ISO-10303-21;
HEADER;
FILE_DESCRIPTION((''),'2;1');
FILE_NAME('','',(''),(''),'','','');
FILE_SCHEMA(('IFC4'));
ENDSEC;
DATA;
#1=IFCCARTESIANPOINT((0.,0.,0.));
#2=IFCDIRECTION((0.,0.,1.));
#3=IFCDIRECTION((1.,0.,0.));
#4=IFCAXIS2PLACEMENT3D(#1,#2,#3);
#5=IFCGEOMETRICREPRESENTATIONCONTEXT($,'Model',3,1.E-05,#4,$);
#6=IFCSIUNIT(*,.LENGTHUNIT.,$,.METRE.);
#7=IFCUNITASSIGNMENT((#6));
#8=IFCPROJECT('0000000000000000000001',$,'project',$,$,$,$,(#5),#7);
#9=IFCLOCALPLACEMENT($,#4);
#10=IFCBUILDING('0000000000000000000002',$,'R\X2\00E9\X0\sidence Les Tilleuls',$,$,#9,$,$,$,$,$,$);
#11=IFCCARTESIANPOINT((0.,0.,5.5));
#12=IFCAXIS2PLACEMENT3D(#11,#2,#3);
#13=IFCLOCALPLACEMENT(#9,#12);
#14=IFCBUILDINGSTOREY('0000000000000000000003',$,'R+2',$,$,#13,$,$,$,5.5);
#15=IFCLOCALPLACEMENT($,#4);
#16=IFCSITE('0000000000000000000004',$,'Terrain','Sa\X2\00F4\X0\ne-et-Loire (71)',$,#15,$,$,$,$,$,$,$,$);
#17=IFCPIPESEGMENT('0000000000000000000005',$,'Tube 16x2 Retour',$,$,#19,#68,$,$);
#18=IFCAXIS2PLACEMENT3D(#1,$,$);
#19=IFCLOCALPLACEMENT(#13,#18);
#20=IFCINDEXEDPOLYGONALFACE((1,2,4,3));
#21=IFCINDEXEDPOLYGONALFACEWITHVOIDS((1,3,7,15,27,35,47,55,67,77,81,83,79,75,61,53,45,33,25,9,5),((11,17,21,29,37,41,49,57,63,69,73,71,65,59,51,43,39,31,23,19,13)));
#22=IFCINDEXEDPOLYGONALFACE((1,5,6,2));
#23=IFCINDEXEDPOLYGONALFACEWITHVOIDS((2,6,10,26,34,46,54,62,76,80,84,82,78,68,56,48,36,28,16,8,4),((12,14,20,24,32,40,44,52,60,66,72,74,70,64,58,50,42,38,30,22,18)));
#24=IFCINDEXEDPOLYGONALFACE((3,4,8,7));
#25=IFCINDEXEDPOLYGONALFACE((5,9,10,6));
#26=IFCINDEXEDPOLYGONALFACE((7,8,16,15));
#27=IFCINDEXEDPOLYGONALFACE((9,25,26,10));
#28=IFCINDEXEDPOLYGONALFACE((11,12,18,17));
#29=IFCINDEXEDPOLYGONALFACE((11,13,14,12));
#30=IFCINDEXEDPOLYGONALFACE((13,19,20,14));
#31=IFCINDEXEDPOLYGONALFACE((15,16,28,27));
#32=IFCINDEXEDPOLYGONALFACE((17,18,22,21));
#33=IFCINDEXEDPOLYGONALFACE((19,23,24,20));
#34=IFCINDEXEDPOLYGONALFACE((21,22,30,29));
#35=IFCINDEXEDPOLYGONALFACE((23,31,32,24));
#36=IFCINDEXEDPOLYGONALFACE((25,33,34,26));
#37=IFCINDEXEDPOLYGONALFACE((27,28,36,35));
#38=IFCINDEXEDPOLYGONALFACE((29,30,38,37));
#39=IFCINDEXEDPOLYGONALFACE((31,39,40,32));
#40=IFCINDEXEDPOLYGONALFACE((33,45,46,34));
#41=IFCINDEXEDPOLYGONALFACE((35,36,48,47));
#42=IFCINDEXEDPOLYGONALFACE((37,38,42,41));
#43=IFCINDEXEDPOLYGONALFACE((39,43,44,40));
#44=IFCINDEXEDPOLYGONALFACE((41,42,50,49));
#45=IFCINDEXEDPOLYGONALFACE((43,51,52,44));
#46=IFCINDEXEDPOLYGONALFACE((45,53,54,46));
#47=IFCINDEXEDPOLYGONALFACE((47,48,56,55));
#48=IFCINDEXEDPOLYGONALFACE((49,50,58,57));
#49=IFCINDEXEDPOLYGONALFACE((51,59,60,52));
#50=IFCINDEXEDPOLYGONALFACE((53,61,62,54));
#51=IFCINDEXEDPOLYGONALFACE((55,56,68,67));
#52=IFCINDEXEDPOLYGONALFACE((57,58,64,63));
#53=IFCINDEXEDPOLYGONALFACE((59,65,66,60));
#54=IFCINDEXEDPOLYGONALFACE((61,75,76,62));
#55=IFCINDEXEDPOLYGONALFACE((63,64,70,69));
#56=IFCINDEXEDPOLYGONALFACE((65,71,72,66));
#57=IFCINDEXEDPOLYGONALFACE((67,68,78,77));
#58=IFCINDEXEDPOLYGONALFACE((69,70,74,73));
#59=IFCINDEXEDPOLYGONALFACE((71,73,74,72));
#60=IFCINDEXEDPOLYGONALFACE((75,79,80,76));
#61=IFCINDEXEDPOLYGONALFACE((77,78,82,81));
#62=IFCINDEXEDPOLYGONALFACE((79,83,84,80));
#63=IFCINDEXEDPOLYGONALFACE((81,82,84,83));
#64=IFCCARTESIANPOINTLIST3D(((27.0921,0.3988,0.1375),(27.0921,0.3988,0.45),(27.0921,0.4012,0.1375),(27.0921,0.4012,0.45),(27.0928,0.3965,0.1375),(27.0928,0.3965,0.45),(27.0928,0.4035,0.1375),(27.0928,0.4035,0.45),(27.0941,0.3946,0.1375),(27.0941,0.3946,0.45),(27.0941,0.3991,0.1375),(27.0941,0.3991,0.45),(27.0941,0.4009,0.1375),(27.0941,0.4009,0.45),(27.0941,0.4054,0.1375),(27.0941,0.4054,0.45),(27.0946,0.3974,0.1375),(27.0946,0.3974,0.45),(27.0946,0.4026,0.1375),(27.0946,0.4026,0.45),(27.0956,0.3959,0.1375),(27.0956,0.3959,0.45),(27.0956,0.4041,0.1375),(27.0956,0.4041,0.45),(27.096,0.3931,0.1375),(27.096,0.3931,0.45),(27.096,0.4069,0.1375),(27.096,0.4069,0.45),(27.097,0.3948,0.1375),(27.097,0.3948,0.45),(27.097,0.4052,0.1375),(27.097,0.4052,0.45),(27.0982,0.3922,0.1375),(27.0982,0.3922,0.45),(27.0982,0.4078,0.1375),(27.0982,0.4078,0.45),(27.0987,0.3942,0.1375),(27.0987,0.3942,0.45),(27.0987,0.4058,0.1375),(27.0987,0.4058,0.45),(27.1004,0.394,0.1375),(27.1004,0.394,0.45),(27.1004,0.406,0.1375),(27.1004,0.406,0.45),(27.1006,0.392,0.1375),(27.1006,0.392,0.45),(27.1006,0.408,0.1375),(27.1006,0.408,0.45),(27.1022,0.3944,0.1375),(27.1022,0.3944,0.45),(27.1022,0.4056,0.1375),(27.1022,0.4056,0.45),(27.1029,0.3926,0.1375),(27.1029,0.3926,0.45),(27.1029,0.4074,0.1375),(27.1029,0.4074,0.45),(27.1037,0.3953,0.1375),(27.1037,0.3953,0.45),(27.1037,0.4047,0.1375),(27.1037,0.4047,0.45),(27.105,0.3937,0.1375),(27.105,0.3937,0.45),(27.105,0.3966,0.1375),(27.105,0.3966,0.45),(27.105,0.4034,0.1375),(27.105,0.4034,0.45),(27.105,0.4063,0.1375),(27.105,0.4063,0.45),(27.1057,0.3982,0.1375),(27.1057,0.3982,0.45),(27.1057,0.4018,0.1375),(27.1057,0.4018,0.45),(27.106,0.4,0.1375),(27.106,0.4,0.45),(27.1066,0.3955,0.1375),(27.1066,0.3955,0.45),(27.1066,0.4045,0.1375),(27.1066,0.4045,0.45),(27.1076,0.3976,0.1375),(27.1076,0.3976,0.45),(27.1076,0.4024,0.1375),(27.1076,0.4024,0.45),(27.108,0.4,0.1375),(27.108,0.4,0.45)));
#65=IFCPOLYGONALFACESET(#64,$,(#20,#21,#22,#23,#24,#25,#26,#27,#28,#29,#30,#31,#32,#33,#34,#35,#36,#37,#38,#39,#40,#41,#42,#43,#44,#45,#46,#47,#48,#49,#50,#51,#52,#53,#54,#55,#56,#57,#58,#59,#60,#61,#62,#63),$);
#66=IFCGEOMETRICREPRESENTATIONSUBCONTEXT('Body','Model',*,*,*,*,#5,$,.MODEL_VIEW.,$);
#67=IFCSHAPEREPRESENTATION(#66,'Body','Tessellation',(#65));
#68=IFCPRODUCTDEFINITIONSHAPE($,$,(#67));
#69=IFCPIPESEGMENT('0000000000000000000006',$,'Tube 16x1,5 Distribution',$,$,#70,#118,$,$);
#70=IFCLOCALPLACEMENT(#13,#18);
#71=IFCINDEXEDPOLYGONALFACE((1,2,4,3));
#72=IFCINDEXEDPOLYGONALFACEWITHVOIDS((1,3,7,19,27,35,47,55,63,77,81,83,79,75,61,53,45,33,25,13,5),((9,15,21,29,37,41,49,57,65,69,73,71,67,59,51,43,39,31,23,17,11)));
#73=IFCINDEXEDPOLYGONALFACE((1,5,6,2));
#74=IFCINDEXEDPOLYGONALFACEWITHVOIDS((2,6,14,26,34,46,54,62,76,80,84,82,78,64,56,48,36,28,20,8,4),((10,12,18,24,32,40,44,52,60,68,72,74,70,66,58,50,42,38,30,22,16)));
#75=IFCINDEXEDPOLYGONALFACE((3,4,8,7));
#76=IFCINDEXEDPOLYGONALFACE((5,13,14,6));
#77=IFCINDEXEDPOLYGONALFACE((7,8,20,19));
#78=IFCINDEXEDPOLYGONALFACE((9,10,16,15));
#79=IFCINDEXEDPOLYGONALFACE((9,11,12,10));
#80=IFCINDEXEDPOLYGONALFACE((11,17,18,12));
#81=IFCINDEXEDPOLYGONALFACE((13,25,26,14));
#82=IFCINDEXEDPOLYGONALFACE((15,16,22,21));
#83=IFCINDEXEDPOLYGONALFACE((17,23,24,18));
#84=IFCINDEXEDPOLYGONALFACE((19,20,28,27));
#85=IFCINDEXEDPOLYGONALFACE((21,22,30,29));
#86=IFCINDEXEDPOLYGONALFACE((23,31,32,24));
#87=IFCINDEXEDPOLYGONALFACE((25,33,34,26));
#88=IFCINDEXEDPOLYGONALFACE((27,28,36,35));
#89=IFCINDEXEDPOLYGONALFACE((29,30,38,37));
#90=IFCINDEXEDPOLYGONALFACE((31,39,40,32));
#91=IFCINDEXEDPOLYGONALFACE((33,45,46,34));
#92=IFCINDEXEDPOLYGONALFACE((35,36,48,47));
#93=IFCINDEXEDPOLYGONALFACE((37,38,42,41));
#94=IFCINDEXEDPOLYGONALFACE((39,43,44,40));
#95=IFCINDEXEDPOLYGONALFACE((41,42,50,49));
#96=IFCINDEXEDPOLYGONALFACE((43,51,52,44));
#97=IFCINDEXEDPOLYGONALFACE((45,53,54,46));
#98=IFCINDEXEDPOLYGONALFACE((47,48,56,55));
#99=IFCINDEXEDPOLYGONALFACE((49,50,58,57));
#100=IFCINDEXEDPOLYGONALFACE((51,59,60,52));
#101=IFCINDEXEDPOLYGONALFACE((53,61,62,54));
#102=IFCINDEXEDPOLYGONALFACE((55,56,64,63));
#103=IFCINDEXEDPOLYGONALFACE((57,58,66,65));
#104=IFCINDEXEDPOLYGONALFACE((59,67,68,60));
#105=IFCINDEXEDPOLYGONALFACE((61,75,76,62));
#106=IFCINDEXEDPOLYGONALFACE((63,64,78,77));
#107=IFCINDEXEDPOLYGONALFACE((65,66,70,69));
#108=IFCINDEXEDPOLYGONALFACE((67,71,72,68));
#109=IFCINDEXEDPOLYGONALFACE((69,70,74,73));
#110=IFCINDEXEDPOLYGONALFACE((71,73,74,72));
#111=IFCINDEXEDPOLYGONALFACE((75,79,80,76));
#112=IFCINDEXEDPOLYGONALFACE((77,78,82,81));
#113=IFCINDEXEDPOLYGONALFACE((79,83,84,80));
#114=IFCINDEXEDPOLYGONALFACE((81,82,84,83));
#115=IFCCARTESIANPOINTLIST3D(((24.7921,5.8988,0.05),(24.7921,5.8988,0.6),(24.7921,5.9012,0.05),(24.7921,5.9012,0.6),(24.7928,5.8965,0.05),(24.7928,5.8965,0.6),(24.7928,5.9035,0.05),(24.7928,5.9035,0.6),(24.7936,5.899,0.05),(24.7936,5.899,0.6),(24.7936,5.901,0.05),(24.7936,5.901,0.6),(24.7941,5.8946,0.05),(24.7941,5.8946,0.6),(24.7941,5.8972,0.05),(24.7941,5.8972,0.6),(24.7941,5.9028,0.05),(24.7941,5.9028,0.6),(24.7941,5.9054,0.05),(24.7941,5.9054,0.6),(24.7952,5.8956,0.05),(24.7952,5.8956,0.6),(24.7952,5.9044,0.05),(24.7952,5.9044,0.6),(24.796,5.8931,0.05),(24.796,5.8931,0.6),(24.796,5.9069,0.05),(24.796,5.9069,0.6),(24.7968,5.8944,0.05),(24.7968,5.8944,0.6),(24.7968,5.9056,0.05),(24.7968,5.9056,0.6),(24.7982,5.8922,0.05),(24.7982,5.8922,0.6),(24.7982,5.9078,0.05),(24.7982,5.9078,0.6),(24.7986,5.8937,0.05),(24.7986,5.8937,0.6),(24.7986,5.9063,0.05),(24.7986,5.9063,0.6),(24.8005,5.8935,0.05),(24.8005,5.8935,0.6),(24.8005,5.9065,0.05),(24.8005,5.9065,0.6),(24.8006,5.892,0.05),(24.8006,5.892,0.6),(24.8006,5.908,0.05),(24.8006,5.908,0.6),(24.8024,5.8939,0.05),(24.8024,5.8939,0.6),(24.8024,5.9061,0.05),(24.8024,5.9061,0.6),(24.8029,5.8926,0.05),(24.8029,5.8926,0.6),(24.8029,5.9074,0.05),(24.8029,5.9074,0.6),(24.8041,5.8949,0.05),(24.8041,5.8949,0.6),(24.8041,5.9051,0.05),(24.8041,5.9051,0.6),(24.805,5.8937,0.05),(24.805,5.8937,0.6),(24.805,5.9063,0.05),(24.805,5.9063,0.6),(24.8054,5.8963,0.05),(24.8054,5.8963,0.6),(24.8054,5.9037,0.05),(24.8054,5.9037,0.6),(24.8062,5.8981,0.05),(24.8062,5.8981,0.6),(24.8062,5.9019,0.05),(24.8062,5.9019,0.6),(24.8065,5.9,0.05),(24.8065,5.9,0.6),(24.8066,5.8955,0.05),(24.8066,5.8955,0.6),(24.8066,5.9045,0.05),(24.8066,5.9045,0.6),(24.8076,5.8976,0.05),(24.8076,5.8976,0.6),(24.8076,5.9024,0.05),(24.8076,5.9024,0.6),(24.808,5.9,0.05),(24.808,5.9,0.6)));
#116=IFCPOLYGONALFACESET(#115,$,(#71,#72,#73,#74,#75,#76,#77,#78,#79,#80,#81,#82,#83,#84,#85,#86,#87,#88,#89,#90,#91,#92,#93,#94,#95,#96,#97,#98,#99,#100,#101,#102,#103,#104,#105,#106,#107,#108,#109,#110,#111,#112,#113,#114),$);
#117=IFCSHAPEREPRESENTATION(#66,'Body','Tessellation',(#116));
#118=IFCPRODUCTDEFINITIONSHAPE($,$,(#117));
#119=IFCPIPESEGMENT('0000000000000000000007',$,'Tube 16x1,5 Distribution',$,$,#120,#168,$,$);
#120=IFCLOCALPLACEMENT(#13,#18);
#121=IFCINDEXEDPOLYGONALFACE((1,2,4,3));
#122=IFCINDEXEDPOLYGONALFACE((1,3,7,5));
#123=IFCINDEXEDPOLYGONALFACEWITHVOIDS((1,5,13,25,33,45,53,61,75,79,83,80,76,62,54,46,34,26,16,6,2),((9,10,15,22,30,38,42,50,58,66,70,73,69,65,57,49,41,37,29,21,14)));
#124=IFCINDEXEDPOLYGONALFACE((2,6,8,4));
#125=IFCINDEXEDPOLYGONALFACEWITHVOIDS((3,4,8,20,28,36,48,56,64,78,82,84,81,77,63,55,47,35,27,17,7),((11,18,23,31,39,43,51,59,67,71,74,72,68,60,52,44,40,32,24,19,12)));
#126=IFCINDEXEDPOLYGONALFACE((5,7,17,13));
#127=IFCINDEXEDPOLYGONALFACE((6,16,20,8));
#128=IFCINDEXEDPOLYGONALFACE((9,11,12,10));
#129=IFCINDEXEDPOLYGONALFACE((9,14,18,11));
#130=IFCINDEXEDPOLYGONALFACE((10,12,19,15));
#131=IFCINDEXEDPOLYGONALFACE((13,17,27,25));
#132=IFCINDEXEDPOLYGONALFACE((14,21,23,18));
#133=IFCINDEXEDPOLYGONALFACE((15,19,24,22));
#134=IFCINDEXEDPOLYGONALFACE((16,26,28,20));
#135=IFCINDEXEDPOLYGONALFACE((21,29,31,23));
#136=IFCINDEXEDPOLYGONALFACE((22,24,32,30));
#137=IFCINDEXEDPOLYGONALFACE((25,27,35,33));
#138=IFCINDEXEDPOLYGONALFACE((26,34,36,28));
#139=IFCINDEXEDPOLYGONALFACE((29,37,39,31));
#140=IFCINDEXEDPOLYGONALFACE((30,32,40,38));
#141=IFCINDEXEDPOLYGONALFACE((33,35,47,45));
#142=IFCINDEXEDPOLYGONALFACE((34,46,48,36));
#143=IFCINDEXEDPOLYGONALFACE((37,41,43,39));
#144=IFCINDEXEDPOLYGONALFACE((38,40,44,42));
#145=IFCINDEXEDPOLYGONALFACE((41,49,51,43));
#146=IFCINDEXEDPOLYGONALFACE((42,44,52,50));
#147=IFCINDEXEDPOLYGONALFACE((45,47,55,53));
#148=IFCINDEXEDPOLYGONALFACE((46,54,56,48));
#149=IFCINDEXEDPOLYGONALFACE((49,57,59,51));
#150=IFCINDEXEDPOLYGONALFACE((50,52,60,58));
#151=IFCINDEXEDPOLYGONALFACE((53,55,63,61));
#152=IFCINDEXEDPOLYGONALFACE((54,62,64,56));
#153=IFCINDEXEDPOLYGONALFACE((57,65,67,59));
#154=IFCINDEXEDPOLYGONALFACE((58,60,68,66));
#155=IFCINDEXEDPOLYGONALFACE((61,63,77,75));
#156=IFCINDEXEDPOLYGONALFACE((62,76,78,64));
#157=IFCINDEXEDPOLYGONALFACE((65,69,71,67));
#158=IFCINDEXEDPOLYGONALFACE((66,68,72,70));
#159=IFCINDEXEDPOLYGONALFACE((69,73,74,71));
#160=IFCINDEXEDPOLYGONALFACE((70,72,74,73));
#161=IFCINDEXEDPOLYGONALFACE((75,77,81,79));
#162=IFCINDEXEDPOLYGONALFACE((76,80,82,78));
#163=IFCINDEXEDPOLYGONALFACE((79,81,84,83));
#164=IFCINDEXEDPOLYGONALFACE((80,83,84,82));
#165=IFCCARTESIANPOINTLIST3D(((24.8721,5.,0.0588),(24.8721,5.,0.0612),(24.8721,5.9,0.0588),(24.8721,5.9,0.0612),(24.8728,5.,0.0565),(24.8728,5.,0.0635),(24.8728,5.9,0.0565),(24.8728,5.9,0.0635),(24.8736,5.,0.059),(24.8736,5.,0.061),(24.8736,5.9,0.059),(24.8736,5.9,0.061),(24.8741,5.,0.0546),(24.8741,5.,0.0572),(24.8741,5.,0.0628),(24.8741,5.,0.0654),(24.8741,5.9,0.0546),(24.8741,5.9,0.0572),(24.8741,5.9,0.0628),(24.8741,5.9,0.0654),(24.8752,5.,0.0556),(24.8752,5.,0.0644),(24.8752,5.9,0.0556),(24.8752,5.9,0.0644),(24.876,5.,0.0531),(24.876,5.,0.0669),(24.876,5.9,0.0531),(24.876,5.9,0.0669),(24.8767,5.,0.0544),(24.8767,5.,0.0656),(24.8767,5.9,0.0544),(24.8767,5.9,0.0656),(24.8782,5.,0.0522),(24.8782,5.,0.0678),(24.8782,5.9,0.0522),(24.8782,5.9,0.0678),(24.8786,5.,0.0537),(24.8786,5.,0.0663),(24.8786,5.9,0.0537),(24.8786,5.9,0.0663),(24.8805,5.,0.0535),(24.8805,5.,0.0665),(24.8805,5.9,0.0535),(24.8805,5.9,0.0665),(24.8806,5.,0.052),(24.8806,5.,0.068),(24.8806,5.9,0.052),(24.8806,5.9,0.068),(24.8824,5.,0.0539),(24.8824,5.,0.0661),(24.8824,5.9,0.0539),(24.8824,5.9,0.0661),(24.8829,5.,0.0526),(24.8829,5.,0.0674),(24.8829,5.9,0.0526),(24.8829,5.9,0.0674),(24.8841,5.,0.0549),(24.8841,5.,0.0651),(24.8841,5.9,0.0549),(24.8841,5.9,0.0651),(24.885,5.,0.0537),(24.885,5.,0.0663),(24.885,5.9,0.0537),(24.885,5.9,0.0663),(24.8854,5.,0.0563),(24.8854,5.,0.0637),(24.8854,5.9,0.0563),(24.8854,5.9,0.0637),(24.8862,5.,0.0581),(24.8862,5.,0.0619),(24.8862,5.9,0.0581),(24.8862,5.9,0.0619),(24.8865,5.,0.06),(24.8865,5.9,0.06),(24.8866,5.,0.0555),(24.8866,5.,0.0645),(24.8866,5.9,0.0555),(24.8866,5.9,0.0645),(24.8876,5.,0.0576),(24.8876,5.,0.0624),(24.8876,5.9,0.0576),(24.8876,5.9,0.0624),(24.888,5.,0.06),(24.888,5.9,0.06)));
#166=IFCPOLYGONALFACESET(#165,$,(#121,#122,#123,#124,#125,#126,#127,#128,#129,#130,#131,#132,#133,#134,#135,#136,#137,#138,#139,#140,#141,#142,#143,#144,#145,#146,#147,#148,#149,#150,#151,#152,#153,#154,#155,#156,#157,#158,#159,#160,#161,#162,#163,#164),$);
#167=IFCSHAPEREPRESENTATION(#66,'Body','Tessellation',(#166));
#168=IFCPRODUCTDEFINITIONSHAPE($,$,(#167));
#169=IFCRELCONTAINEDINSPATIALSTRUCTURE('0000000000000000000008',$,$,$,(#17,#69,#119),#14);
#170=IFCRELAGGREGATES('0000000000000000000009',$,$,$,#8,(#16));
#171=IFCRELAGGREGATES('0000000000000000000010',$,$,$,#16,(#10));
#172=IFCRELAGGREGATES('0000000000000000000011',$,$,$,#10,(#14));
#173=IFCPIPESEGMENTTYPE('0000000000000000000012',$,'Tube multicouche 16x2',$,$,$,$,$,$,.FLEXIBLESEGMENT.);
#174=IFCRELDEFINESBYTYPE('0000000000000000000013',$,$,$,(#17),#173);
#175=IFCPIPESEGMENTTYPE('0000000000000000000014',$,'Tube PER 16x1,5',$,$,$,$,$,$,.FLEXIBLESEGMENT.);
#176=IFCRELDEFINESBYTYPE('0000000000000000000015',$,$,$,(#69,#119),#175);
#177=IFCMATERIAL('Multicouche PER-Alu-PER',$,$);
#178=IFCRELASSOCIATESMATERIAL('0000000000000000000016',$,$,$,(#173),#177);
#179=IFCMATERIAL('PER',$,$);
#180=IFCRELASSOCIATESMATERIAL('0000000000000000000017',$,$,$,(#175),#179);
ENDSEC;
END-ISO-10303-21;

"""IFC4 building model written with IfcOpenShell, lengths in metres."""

from ifc_helpers import new_model, si_unit, frame, origin_with_axes, place, context, subcontext, project, spatial, hollow_circle, extrude, material, type_object, element, save


model = new_model("IFC4")

# Units and contexts
model_context = context("Model", 3, precision=1e-05, world=origin_with_axes())
body_context = subcontext(model_context, "Body", "Model", "MODEL_VIEW")
ifc_project = project(units=[si_unit("LENGTHUNIT", "METRE")], contexts=[model_context])

# Site, building, storey
site_placement = place(None, origin_with_axes())
site = spatial("IfcSite", under=ifc_project, at=site_placement, Name="Terrain", Description="Saône-et-Loire (71)")
building_placement = place(None, origin_with_axes())
building = spatial("IfcBuilding", under=site, at=building_placement, Name="Résidence Les Tilleuls")
storey_placement = place(building_placement, frame((0.0, 0.0, 5.5), z_axis=(0.0, 0.0, 1.0), x_axis=(1.0, 0.0, 0.0)))
storey = spatial("IfcBuildingStorey", under=building, at=storey_placement, Name="R+2", Elevation=5.5)

# Pipe segments
ifc_material_1 = material(Name="Multicouche PER-Alu-PER")
pipe_segment_type_1 = type_object("IfcPipeSegmentType", Name="Tube multicouche 16x2", PredefinedType="FLEXIBLESEGMENT", material=ifc_material_1)
pipe_segment_1_placement = place(storey_placement, frame((27.1, 0.4, 0.1375), z_axis=(0.0, 0.0, 1.0), x_axis=(1.0, 0.0, 0.0)))
element("IfcPipeSegment", 1, at=pipe_segment_1_placement, inside=storey, type_object=pipe_segment_type_1, Name="Tube 16x2 Retour", context=body_context, shape_type="SweptSolid", body=[
    extrude(hollow_circle(Radius=0.008, WallThickness=0.002), origin_with_axes(), (0.0, 0.0, 1.0), 0.3125),
])
ifc_material_2 = material(Name="PER")
pipe_segment_type_2 = type_object("IfcPipeSegmentType", Name="Tube PER 16x1,5", PredefinedType="FLEXIBLESEGMENT", material=ifc_material_2)
pipe_segment_2_placement = place(storey_placement, frame((24.8, 5.9, 0.05), z_axis=(0.0, 0.0, 1.0), x_axis=(1.0, 0.0, 0.0)))
element("IfcPipeSegment", 2, at=pipe_segment_2_placement, inside=storey, type_object=pipe_segment_type_2, Name="Tube 16x1,5 Distribution", context=body_context, shape_type="SweptSolid", body=[
    extrude(hollow_circle(Radius=0.008, WallThickness=0.0015), origin_with_axes(), (0.0, 0.0, 1.0), 0.55),
])
pipe_segment_3_placement = place(storey_placement, frame((24.88, 5.0, 0.06), z_axis=(0.0, 1.0, 0.0), x_axis=(1.0, 0.0, 0.0)))
element("IfcPipeSegment", 3, at=pipe_segment_3_placement, inside=storey, type_object=pipe_segment_type_2, Name="Tube 16x1,5 Distribution", context=body_context, shape_type="SweptSolid", body=[
    extrude(hollow_circle(Radius=0.008, WallThickness=0.0015), origin_with_axes(), (0.0, 0.0, 1.0), 0.9),
])

save(model, "model.ifc")
